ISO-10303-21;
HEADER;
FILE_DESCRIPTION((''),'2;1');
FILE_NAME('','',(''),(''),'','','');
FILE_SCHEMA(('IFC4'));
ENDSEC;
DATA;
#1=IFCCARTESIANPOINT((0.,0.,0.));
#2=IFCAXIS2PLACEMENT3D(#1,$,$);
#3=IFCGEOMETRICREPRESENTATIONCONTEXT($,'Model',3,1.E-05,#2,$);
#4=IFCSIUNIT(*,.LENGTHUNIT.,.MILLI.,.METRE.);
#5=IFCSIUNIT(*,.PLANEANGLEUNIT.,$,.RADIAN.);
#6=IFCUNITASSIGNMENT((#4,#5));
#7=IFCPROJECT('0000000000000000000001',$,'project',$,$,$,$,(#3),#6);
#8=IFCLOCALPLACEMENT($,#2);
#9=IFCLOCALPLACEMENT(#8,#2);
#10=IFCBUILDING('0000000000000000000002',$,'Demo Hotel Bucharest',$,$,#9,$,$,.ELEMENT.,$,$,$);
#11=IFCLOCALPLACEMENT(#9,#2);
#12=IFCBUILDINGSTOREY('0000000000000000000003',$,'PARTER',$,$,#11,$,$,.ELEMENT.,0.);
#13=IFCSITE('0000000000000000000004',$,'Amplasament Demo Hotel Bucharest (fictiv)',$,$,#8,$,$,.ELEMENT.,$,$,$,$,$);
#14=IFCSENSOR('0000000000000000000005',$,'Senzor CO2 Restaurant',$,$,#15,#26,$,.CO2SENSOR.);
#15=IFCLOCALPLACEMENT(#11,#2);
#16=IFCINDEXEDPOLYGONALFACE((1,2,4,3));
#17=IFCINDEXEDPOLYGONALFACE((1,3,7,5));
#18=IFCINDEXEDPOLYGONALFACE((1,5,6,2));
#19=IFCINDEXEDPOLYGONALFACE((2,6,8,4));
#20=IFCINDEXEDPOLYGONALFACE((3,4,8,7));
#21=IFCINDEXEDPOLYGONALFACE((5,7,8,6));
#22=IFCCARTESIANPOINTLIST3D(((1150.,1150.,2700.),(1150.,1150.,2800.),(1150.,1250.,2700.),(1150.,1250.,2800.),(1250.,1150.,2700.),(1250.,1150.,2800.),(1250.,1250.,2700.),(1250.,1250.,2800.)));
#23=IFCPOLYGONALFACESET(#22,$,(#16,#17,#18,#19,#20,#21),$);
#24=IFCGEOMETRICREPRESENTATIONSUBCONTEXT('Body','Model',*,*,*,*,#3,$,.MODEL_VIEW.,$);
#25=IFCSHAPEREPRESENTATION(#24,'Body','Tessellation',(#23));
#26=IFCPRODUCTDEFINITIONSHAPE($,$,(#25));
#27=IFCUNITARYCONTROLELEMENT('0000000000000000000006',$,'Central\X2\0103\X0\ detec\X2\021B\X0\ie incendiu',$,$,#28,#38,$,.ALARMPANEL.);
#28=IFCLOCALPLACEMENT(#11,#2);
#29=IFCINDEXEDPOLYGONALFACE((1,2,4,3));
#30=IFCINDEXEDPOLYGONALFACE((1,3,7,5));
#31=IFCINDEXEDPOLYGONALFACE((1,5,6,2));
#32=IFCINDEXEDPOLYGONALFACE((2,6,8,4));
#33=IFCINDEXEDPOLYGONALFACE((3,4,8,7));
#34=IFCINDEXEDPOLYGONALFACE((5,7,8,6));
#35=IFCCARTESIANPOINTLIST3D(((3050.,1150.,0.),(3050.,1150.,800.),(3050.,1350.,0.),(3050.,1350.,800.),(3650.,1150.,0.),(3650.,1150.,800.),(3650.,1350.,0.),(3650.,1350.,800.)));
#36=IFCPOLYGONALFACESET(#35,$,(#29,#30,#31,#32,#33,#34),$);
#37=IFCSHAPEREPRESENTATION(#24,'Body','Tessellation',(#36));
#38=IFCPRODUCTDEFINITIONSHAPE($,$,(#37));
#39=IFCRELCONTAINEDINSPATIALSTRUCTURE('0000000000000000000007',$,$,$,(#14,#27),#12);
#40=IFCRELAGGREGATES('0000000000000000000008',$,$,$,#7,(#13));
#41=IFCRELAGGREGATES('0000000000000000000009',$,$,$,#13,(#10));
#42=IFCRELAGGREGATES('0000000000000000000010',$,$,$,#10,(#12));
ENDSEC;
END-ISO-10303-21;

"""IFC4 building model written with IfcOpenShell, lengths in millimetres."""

from ifc_helpers import new_model, si_unit, frame, frame_2d, origin, place, context, subcontext, project, spatial, rectangle, extrude, element, save


model = new_model("IFC4")

# Units and contexts
model_context = context("Model", 3, precision=1e-05, world=origin())
body_context = subcontext(model_context, "Body", "Model", "MODEL_VIEW")
ifc_project = project(units=[si_unit("LENGTHUNIT", "METRE", prefix="MILLI"), si_unit("PLANEANGLEUNIT", "RADIAN")], contexts=[model_context])

# Site, building, storey
site_placement = place(None, origin())
site = spatial("IfcSite", under=ifc_project, at=site_placement, Name="Amplasament Demo Hotel Bucharest (fictiv)", CompositionType="ELEMENT")
building_placement = place(site_placement, origin())
building = spatial("IfcBuilding", under=site, at=building_placement, Name="Demo Hotel Bucharest", CompositionType="ELEMENT")
storey_placement = place(building_placement, origin())
storey = spatial("IfcBuildingStorey", under=building, at=storey_placement, Name="PARTER", CompositionType="ELEMENT", Elevation=0.0)

# Sensor
sensor_placement = place(storey_placement, frame((1150.0, 1150.0, 2700.0)))
element("IfcSensor", 1, at=sensor_placement, inside=storey, Name="Senzor CO2 Restaurant", PredefinedType="CO2SENSOR", context=body_context, shape_type="SweptSolid", body=[
    extrude(rectangle(XDim=100.0, YDim=100.0, at=frame_2d((50.0, 50.0))), origin(), (0.0, 0.0, 1.0), 100.0),
])

# Unitary control element
unitary_control_element_placement = place(storey_placement, frame((3050.0, 1150.0, 0.0)))
element("IfcUnitaryControlElement", 2, at=unitary_control_element_placement, inside=storey, Name="Centrală detecție incendiu", PredefinedType="ALARMPANEL", context=body_context, shape_type="SweptSolid", body=[
    extrude(rectangle(XDim=600.0, YDim=200.0, at=frame_2d((300.0, 100.0))), origin(), (0.0, 0.0, 1.0), 800.0),
])

save(model, "model.ifc")
